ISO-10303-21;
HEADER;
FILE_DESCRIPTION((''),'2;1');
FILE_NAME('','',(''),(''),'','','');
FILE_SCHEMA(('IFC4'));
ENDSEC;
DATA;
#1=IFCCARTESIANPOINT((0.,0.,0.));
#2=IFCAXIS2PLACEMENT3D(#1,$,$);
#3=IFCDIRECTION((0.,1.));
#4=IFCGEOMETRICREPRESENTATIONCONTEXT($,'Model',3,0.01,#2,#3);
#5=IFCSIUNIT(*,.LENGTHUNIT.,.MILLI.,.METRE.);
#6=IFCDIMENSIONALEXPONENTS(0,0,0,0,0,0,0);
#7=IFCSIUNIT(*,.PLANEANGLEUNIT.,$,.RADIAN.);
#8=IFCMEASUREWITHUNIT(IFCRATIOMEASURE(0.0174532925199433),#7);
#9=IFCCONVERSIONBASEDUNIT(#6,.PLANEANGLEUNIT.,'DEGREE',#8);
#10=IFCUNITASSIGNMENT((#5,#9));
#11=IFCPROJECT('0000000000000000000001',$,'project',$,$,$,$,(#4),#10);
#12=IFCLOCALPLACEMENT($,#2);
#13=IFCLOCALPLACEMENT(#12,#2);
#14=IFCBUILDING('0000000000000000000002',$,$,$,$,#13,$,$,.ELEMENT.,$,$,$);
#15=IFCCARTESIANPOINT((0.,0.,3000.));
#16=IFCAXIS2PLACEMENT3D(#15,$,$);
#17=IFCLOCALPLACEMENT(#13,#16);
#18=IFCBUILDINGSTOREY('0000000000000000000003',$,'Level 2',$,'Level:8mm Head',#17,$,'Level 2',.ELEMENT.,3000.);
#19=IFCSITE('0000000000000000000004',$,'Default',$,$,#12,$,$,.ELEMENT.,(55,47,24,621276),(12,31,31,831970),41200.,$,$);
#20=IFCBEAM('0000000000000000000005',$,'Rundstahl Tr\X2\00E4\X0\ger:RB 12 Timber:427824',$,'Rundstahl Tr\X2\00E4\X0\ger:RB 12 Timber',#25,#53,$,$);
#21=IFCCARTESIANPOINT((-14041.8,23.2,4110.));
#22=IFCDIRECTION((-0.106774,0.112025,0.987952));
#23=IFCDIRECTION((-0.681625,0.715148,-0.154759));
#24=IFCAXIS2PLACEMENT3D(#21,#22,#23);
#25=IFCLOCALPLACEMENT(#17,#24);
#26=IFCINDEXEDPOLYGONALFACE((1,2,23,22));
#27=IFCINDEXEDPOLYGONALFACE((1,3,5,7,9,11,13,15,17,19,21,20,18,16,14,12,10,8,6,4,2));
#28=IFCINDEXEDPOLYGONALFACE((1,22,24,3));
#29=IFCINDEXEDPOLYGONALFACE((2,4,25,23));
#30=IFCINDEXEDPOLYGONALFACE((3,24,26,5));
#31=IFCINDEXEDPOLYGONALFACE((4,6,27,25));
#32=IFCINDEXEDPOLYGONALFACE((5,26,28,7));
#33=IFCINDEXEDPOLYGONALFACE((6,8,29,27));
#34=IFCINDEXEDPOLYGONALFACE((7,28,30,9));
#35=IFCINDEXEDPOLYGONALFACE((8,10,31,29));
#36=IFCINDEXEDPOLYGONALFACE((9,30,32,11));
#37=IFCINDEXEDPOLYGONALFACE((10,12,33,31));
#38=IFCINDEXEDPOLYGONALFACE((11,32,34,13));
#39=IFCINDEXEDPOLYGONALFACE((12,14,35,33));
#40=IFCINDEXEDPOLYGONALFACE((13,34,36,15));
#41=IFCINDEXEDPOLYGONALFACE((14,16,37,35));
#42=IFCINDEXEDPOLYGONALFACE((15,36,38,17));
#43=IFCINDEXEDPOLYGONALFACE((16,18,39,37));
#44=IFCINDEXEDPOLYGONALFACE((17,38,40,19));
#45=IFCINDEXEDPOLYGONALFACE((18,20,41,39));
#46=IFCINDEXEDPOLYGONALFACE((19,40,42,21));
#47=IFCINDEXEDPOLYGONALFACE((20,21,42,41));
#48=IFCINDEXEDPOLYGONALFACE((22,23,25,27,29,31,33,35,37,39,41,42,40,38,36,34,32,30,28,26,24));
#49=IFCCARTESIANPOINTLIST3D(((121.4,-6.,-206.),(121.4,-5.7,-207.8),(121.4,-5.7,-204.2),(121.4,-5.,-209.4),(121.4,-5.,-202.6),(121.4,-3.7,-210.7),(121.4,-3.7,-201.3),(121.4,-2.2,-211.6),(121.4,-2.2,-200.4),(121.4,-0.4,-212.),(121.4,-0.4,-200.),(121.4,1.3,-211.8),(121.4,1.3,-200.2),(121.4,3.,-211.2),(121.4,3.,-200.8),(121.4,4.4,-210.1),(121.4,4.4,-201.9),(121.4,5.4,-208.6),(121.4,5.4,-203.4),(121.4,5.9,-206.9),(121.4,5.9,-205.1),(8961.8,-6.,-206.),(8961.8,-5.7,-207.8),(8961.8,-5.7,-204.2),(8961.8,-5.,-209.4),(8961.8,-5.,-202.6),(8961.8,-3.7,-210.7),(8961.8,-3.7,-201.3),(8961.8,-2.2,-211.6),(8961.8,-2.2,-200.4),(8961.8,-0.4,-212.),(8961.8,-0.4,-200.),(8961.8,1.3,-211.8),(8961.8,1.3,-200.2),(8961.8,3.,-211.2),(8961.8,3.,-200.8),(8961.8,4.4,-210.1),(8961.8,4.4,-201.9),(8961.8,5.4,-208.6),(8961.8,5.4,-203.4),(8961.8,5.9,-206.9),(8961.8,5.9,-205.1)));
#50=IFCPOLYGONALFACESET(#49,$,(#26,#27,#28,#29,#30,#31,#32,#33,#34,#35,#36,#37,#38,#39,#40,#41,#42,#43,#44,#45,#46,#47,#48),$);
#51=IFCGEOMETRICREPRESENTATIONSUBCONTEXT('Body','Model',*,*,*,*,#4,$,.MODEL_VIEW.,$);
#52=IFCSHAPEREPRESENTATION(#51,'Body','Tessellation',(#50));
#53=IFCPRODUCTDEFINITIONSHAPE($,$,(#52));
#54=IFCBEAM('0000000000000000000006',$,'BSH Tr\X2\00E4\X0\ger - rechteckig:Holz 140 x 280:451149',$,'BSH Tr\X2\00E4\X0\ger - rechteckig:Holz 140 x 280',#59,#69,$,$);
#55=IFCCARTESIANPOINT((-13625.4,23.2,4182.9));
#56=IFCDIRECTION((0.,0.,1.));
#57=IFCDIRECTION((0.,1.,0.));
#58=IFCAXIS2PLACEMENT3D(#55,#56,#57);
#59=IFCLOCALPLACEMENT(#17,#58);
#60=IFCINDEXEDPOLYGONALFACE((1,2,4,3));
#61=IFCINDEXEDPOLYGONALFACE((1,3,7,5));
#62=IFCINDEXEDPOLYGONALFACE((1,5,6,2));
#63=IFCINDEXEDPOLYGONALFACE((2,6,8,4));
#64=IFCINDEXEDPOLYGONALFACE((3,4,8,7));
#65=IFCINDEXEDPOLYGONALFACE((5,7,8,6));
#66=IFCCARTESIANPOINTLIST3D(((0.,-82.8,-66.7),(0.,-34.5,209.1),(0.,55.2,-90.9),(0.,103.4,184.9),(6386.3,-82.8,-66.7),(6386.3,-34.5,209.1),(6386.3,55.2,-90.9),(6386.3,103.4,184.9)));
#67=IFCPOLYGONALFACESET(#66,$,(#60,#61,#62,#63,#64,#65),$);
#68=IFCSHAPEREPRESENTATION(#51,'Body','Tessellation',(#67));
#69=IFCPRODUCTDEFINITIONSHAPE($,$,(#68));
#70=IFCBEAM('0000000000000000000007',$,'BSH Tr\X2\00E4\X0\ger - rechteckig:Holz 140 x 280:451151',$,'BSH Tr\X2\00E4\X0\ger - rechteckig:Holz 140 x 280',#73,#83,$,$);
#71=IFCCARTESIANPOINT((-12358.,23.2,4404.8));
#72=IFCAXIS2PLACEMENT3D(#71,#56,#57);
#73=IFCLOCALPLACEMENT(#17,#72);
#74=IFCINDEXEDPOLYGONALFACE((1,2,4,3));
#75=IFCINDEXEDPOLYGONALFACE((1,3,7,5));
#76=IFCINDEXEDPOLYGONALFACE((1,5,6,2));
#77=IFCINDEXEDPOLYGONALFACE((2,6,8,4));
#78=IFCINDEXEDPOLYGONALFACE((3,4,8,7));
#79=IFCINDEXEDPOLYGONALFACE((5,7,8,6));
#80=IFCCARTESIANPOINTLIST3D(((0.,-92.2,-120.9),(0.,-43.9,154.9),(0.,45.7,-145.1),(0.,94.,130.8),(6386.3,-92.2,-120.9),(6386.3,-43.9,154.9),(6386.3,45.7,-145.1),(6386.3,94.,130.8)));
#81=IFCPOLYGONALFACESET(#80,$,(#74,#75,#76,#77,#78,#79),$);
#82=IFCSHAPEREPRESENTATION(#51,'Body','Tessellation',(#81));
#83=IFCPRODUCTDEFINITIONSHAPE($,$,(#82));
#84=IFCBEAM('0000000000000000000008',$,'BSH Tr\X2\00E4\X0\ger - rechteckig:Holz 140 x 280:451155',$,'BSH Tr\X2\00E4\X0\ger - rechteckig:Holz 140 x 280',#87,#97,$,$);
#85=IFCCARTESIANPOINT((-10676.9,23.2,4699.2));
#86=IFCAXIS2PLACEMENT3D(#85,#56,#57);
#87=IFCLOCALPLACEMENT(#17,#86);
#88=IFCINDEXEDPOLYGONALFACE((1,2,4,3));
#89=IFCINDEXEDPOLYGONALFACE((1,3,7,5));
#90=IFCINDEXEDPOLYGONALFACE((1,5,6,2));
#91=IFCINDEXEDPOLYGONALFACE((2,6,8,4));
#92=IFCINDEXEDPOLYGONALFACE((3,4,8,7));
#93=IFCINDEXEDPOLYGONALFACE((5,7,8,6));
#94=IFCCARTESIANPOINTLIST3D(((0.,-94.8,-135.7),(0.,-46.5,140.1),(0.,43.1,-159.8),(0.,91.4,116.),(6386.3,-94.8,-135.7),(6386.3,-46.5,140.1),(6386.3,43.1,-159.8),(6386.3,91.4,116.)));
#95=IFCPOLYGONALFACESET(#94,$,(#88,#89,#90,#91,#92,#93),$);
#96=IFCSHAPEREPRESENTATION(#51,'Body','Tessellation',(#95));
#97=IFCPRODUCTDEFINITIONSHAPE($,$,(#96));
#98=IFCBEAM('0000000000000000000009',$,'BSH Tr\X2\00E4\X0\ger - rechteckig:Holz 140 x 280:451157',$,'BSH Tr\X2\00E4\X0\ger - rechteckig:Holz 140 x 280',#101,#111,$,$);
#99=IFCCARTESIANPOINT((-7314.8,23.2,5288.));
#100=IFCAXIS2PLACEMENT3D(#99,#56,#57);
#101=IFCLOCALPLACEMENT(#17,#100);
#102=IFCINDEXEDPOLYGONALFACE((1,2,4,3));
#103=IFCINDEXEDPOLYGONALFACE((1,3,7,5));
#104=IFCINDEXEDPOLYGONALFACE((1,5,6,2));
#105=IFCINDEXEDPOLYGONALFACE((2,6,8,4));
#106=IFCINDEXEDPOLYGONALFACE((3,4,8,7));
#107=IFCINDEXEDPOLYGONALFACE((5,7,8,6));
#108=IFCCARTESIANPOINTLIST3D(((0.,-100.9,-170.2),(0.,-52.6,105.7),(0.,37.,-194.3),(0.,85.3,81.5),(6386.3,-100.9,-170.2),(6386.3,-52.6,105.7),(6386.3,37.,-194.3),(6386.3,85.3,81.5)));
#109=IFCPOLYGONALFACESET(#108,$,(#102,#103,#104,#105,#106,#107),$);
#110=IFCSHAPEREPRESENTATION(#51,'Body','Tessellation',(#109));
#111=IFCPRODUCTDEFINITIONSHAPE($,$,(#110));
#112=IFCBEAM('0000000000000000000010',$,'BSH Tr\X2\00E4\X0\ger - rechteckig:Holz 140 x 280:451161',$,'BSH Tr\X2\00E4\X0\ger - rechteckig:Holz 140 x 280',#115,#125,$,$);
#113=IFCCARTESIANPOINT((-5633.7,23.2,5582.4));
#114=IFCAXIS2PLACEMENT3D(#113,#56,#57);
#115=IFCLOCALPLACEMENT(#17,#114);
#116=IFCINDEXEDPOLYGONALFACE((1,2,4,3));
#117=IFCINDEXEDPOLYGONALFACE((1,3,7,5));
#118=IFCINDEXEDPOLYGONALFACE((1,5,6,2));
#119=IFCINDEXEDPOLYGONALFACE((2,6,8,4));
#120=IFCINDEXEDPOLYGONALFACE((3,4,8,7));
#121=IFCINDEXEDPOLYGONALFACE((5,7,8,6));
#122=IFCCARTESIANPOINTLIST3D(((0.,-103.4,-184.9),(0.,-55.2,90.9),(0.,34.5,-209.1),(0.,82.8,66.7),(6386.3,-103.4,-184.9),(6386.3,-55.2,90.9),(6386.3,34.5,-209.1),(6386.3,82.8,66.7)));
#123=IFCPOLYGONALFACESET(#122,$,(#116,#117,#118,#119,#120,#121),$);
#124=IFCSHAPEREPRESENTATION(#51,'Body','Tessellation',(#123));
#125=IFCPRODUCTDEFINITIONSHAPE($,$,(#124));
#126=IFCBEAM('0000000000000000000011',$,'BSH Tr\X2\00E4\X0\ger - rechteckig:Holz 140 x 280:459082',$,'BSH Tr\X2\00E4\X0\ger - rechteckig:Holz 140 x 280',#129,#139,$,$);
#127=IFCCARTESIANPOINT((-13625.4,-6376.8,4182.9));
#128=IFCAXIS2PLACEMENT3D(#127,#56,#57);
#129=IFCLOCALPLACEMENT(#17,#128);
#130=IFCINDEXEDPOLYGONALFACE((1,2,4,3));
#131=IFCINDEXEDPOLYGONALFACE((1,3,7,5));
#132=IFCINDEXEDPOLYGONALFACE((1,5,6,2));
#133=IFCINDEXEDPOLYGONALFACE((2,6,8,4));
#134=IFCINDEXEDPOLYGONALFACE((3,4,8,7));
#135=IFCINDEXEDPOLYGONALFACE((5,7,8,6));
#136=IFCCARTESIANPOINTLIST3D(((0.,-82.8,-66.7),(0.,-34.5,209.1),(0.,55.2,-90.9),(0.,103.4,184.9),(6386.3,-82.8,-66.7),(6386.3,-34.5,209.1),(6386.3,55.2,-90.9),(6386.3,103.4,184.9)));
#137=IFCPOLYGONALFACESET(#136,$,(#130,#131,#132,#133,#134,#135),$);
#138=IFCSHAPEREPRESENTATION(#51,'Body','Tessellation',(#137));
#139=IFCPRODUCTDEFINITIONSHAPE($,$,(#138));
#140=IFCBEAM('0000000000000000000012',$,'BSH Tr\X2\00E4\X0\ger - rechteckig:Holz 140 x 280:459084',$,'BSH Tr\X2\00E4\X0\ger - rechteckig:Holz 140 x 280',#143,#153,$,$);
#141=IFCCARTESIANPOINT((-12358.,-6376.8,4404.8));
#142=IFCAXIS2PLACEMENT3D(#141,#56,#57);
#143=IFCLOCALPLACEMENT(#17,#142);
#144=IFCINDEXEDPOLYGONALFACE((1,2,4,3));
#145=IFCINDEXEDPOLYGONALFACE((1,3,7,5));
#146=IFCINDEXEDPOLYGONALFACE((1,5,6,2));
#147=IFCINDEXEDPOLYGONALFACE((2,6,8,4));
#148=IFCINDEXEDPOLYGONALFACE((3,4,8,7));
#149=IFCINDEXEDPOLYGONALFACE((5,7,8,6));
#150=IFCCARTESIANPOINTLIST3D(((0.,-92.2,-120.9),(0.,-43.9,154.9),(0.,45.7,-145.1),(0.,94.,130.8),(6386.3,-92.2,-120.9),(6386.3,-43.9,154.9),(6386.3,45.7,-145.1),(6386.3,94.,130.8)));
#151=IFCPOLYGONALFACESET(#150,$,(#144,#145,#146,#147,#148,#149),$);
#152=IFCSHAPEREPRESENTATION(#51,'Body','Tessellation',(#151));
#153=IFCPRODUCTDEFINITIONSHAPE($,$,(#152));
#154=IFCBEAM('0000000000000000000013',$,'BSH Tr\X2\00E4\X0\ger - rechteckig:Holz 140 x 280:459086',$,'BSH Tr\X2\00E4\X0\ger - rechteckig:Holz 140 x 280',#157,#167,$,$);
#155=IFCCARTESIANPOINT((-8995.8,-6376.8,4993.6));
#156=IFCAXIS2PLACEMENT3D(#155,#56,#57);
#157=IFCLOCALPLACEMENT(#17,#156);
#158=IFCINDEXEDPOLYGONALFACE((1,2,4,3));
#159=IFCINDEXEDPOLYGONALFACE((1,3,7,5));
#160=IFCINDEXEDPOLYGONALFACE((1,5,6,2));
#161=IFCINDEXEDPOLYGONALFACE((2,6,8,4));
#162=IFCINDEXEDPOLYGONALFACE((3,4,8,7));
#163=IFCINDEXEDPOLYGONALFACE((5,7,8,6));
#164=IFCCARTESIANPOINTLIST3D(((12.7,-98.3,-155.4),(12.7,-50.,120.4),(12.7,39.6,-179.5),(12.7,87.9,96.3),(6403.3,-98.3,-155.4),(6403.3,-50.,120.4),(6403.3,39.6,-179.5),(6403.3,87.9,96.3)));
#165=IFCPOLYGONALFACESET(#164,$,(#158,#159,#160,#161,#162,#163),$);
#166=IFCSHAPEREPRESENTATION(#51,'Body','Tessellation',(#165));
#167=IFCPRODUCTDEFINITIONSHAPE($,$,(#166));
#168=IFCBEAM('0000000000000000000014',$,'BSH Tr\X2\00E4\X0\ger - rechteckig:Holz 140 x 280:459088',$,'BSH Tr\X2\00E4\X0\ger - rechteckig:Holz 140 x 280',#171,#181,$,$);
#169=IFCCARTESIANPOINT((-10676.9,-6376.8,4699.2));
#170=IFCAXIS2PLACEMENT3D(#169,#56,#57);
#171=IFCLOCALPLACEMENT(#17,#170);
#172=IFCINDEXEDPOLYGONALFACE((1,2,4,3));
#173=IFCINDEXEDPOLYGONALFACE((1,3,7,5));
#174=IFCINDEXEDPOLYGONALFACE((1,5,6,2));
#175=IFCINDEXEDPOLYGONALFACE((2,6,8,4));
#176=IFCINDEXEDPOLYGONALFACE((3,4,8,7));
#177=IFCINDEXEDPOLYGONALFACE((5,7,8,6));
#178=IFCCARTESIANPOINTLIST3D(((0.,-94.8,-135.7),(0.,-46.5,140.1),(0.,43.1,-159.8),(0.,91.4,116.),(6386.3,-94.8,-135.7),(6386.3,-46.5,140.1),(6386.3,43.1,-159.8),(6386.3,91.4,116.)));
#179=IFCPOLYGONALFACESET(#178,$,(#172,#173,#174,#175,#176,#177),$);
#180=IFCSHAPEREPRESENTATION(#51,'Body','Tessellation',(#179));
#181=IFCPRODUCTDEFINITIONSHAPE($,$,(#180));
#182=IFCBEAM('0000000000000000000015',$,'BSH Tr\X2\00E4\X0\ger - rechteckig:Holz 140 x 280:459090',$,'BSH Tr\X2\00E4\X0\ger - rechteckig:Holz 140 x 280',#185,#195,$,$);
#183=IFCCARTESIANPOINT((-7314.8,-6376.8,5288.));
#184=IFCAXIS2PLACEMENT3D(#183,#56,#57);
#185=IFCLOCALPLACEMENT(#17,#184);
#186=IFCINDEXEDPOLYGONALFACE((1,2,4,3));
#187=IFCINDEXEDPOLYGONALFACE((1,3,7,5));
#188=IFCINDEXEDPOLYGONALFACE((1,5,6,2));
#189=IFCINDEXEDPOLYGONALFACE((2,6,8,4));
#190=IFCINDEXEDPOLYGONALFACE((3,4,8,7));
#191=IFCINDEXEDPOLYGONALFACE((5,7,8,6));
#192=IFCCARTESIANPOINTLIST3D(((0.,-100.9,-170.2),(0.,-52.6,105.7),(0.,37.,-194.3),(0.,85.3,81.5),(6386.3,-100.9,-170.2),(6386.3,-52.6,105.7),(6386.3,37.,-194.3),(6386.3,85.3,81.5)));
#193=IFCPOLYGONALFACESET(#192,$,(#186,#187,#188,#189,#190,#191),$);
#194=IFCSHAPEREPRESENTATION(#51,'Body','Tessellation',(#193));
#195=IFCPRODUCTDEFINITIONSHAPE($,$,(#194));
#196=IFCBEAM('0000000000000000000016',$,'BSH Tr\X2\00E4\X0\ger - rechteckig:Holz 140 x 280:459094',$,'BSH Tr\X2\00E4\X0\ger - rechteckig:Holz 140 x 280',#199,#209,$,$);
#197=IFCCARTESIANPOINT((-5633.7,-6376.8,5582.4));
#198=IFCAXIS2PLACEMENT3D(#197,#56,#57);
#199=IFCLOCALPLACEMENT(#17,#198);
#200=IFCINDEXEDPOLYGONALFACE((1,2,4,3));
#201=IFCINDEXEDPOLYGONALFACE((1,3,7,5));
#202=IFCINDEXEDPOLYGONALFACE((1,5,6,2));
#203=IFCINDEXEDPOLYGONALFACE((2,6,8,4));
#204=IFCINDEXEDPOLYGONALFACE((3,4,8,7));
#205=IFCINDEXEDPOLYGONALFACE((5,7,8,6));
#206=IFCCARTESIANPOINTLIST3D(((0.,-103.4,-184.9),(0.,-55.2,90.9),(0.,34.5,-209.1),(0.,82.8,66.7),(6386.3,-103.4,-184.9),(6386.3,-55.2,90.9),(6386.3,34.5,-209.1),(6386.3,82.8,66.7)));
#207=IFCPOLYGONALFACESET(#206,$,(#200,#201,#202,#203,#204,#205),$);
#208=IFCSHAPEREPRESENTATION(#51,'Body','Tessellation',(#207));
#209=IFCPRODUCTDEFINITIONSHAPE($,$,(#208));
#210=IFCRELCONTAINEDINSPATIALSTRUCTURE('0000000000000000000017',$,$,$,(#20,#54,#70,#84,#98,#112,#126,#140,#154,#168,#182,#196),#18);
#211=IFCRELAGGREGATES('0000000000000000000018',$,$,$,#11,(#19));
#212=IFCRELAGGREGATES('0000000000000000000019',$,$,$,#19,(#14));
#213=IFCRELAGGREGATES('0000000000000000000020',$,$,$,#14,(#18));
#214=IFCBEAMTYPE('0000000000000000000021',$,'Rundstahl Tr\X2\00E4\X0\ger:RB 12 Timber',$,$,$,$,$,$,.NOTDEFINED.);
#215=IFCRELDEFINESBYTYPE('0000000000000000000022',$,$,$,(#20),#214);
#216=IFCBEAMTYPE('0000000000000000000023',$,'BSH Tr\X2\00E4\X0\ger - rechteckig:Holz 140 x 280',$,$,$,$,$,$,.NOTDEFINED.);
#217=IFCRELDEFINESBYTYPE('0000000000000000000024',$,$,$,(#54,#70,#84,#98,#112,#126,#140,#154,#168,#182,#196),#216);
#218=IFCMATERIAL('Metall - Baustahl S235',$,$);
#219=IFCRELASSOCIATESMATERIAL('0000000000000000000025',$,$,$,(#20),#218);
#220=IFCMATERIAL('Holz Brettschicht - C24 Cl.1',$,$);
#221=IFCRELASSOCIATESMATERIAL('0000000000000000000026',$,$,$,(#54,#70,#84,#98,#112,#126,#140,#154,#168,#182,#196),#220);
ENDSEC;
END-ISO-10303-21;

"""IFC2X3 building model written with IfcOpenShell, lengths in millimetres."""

from ifc_helpers import new_model, entity, si_unit, converted_unit, direction, frame, frame_2d, origin, origin_2d_with_axis, place, context, subcontext, project, spatial, rectangle, circle, extrude, material, type_object, element, save


model = new_model("IFC2X3")

# Units and contexts
model_context = context("Model", 3, precision=0.01, world=origin(), true_north=direction((0.0, 1.0)))
body_context = subcontext(model_context, "Body", "Model", "MODEL_VIEW")
ifc_project = project(units=[si_unit("LENGTHUNIT", "METRE", prefix="MILLI"), converted_unit("PLANEANGLEUNIT", "DEGREE", entity("IfcRatioMeasure", 0.0174532925199433), si_unit("PLANEANGLEUNIT", "RADIAN"), dimensions=[0, 0, 0, 0, 0, 0, 0])], contexts=[model_context])

# Site, building, storey
site_placement = place(None, origin())
site = spatial("IfcSite", under=ifc_project, at=site_placement, Name="Default", CompositionType="ELEMENT", RefLatitude=(55, 47, 24, 621276), RefLongitude=(12, 31, 31, 831970), RefElevation=41200.0)
building_placement = place(site_placement, origin())
building = spatial("IfcBuilding", under=site, at=building_placement, CompositionType="ELEMENT")
storey_placement = place(building_placement, frame((0.0, 0.0, 3000.0)))
storey = spatial("IfcBuildingStorey", under=building, at=storey_placement, Name="Level 2", ObjectType="Level:8mm Head", LongName="Level 2", CompositionType="ELEMENT", Elevation=3000.0)

# Beams
ifc_material_1 = material(Name="Metall - Baustahl S235")
beam_type_1 = type_object("IfcBeamType", Name="Rundstahl Träger:RB 12 Timber", PredefinedType="NOTDEFINED")
beam_1_placement = place(storey_placement, frame((-14041.8, 23.2, 4110.0), z_axis=(-0.106774, 0.112025, 0.987952), x_axis=(-0.681625, 0.715148, -0.154759)))
element("IfcBeam", 1, at=beam_1_placement, inside=storey, type_object=beam_type_1, material=ifc_material_1, Name="Rundstahl Träger:RB 12 Timber:427824", ObjectType="Rundstahl Träger:RB 12 Timber", context=body_context, shape_type="SweptSolid", body=[
    extrude(circle(Radius=6.0, at=frame_2d((0.0, 0.0), x_axis=(1.0, 0.0))), frame((121.4, 0.0, -206.0), z_axis=(1.0, 0.0, 0.0), x_axis=(0.0, -1.0, 0.0)), (0.0, 0.0, 1.0), 8840.4),
])
ifc_material_2 = material(Name="Holz Brettschicht - C24 Cl.1")
beam_type_2 = type_object("IfcBeamType", Name="BSH Träger - rechteckig:Holz 140 x 280", PredefinedType="NOTDEFINED")
beam_2_placement = place(storey_placement, frame((-13625.4, 23.2, 4182.9), z_axis=(0.0, 0.0, 1.0), x_axis=(0.0, 1.0, 0.0)))
element("IfcBeam", 2, at=beam_2_placement, inside=storey, type_object=beam_type_2, material=ifc_material_2, Name="BSH Träger - rechteckig:Holz 140 x 280:451149", ObjectType="BSH Träger - rechteckig:Holz 140 x 280", context=body_context, shape_type="SweptSolid", body=[
    extrude(rectangle(XDim=280.0, YDim=140.0, at=origin_2d_with_axis()), frame((0.0, 10.3, 59.1), z_axis=(1.0, 0.0, 0.0), x_axis=(0.0, 0.172491, 0.985011)), (0.0, 0.0, 1.0), 6386.3),
])
beam_3_placement = place(storey_placement, frame((-12358.0, 23.2, 4404.8), z_axis=(0.0, 0.0, 1.0), x_axis=(0.0, 1.0, 0.0)))
element("IfcBeam", 3, at=beam_3_placement, inside=storey, type_object=beam_type_2, material=ifc_material_2, Name="BSH Träger - rechteckig:Holz 140 x 280:451151", ObjectType="BSH Träger - rechteckig:Holz 140 x 280", context=body_context, shape_type="SweptSolid", body=[
    extrude(rectangle(XDim=280.0, YDim=140.0, at=origin_2d_with_axis()), frame((0.0, 0.9, 4.9), z_axis=(1.0, 0.0, 0.0), x_axis=(0.0, 0.172491, 0.985011)), (0.0, 0.0, 1.0), 6386.3),
])
beam_4_placement = place(storey_placement, frame((-10676.9, 23.2, 4699.2), z_axis=(0.0, 0.0, 1.0), x_axis=(0.0, 1.0, 0.0)))
element("IfcBeam", 4, at=beam_4_placement, inside=storey, type_object=beam_type_2, material=ifc_material_2, Name="BSH Träger - rechteckig:Holz 140 x 280:451155", ObjectType="BSH Träger - rechteckig:Holz 140 x 280", context=body_context, shape_type="SweptSolid", body=[
    extrude(rectangle(XDim=280.0, YDim=140.0, at=origin_2d_with_axis()), frame((0.0, -1.7, -9.9), z_axis=(1.0, 0.0, 0.0), x_axis=(0.0, 0.172491, 0.985011)), (0.0, 0.0, 1.0), 6386.3),
])
beam_5_placement = place(storey_placement, frame((-7314.8, 23.2, 5288.0), z_axis=(0.0, 0.0, 1.0), x_axis=(0.0, 1.0, 0.0)))
element("IfcBeam", 5, at=beam_5_placement, inside=storey, type_object=beam_type_2, material=ifc_material_2, Name="BSH Träger - rechteckig:Holz 140 x 280:451157", ObjectType="BSH Träger - rechteckig:Holz 140 x 280", context=body_context, shape_type="SweptSolid", body=[
    extrude(rectangle(XDim=280.0, YDim=140.0, at=frame_2d((0.0, 0.0), x_axis=(1.0, 0.0))), frame((0.0, -7.8, -44.3), z_axis=(1.0, 0.0, 0.0), x_axis=(0.0, 0.172491, 0.985011)), (0.0, 0.0, 1.0), 6386.3),
])
beam_6_placement = place(storey_placement, frame((-5633.7, 23.2, 5582.4), z_axis=(0.0, 0.0, 1.0), x_axis=(0.0, 1.0, 0.0)))
element("IfcBeam", 6, at=beam_6_placement, inside=storey, type_object=beam_type_2, material=ifc_material_2, Name="BSH Träger - rechteckig:Holz 140 x 280:451161", ObjectType="BSH Träger - rechteckig:Holz 140 x 280", context=body_context, shape_type="SweptSolid", body=[
    extrude(rectangle(XDim=280.0, YDim=140.0, at=origin_2d_with_axis()), frame((0.0, -10.3, -59.1), z_axis=(1.0, 0.0, 0.0), x_axis=(0.0, 0.172491, 0.985011)), (0.0, 0.0, 1.0), 6386.3),
])
beam_7_placement = place(storey_placement, frame((-13625.4, -6376.8, 4182.9), z_axis=(0.0, 0.0, 1.0), x_axis=(0.0, 1.0, 0.0)))
element("IfcBeam", 7, at=beam_7_placement, inside=storey, type_object=beam_type_2, material=ifc_material_2, Name="BSH Träger - rechteckig:Holz 140 x 280:459082", ObjectType="BSH Träger - rechteckig:Holz 140 x 280", context=body_context, shape_type="SweptSolid", body=[
    extrude(rectangle(XDim=280.0, YDim=140.0, at=frame_2d((0.0, 0.0), x_axis=(1.0, 0.0))), frame((0.0, 10.3, 59.1), z_axis=(1.0, 0.0, 0.0), x_axis=(0.0, 0.172491, 0.985011)), (0.0, 0.0, 1.0), 6386.3),
])
beam_8_placement = place(storey_placement, frame((-12358.0, -6376.8, 4404.8), z_axis=(0.0, 0.0, 1.0), x_axis=(0.0, 1.0, 0.0)))
element("IfcBeam", 8, at=beam_8_placement, inside=storey, type_object=beam_type_2, material=ifc_material_2, Name="BSH Träger - rechteckig:Holz 140 x 280:459084", ObjectType="BSH Träger - rechteckig:Holz 140 x 280", context=body_context, shape_type="SweptSolid", body=[
    extrude(rectangle(XDim=280.0, YDim=140.0, at=origin_2d_with_axis()), frame((0.0, 0.9, 4.9), z_axis=(1.0, 0.0, 0.0), x_axis=(0.0, 0.172491, 0.985011)), (0.0, 0.0, 1.0), 6386.3),
])
beam_9_placement = place(storey_placement, frame((-8995.8, -6376.8, 4993.6), z_axis=(0.0, 0.0, 1.0), x_axis=(0.0, 1.0, 0.0)))
element("IfcBeam", 9, at=beam_9_placement, inside=storey, type_object=beam_type_2, material=ifc_material_2, Name="BSH Träger - rechteckig:Holz 140 x 280:459086", ObjectType="BSH Träger - rechteckig:Holz 140 x 280", context=body_context, shape_type="SweptSolid", body=[
    extrude(rectangle(XDim=280.0, YDim=140.0, at=origin_2d_with_axis()), frame((12.7, -5.2, -29.6), z_axis=(1.0, 0.0, 0.0), x_axis=(0.0, 0.172491, 0.985011)), (0.0, 0.0, 1.0), 6390.6),
])
beam_10_placement = place(storey_placement, frame((-10676.9, -6376.8, 4699.2), z_axis=(0.0, 0.0, 1.0), x_axis=(0.0, 1.0, 0.0)))
element("IfcBeam", 10, at=beam_10_placement, inside=storey, type_object=beam_type_2, material=ifc_material_2, Name="BSH Träger - rechteckig:Holz 140 x 280:459088", ObjectType="BSH Träger - rechteckig:Holz 140 x 280", context=body_context, shape_type="SweptSolid", body=[
    extrude(rectangle(XDim=280.0, YDim=140.0, at=origin_2d_with_axis()), frame((0.0, -1.7, -9.9), z_axis=(1.0, 0.0, 0.0), x_axis=(0.0, 0.172491, 0.985011)), (0.0, 0.0, 1.0), 6386.3),
])
beam_11_placement = place(storey_placement, frame((-7314.8, -6376.8, 5288.0), z_axis=(0.0, 0.0, 1.0), x_axis=(0.0, 1.0, 0.0)))
element("IfcBeam", 11, at=beam_11_placement, inside=storey, type_object=beam_type_2, material=ifc_material_2, Name="BSH Träger - rechteckig:Holz 140 x 280:459090", ObjectType="BSH Träger - rechteckig:Holz 140 x 280", context=body_context, shape_type="SweptSolid", body=[
    extrude(rectangle(XDim=280.0, YDim=140.0, at=frame_2d((0.0, 0.0), x_axis=(1.0, 0.0))), frame((0.0, -7.8, -44.3), z_axis=(1.0, 0.0, 0.0), x_axis=(0.0, 0.172491, 0.985011)), (0.0, 0.0, 1.0), 6386.3),
])
beam_12_placement = place(storey_placement, frame((-5633.7, -6376.8, 5582.4), z_axis=(0.0, 0.0, 1.0), x_axis=(0.0, 1.0, 0.0)))
element("IfcBeam", 12, at=beam_12_placement, inside=storey, type_object=beam_type_2, material=ifc_material_2, Name="BSH Träger - rechteckig:Holz 140 x 280:459094", ObjectType="BSH Träger - rechteckig:Holz 140 x 280", context=body_context, shape_type="SweptSolid", body=[
    extrude(rectangle(XDim=280.0, YDim=140.0, at=origin_2d_with_axis()), frame((0.0, -10.3, -59.1), z_axis=(1.0, 0.0, 0.0), x_axis=(0.0, 0.172491, 0.985011)), (0.0, 0.0, 1.0), 6386.3),
])

save(model, "model.ifc")
